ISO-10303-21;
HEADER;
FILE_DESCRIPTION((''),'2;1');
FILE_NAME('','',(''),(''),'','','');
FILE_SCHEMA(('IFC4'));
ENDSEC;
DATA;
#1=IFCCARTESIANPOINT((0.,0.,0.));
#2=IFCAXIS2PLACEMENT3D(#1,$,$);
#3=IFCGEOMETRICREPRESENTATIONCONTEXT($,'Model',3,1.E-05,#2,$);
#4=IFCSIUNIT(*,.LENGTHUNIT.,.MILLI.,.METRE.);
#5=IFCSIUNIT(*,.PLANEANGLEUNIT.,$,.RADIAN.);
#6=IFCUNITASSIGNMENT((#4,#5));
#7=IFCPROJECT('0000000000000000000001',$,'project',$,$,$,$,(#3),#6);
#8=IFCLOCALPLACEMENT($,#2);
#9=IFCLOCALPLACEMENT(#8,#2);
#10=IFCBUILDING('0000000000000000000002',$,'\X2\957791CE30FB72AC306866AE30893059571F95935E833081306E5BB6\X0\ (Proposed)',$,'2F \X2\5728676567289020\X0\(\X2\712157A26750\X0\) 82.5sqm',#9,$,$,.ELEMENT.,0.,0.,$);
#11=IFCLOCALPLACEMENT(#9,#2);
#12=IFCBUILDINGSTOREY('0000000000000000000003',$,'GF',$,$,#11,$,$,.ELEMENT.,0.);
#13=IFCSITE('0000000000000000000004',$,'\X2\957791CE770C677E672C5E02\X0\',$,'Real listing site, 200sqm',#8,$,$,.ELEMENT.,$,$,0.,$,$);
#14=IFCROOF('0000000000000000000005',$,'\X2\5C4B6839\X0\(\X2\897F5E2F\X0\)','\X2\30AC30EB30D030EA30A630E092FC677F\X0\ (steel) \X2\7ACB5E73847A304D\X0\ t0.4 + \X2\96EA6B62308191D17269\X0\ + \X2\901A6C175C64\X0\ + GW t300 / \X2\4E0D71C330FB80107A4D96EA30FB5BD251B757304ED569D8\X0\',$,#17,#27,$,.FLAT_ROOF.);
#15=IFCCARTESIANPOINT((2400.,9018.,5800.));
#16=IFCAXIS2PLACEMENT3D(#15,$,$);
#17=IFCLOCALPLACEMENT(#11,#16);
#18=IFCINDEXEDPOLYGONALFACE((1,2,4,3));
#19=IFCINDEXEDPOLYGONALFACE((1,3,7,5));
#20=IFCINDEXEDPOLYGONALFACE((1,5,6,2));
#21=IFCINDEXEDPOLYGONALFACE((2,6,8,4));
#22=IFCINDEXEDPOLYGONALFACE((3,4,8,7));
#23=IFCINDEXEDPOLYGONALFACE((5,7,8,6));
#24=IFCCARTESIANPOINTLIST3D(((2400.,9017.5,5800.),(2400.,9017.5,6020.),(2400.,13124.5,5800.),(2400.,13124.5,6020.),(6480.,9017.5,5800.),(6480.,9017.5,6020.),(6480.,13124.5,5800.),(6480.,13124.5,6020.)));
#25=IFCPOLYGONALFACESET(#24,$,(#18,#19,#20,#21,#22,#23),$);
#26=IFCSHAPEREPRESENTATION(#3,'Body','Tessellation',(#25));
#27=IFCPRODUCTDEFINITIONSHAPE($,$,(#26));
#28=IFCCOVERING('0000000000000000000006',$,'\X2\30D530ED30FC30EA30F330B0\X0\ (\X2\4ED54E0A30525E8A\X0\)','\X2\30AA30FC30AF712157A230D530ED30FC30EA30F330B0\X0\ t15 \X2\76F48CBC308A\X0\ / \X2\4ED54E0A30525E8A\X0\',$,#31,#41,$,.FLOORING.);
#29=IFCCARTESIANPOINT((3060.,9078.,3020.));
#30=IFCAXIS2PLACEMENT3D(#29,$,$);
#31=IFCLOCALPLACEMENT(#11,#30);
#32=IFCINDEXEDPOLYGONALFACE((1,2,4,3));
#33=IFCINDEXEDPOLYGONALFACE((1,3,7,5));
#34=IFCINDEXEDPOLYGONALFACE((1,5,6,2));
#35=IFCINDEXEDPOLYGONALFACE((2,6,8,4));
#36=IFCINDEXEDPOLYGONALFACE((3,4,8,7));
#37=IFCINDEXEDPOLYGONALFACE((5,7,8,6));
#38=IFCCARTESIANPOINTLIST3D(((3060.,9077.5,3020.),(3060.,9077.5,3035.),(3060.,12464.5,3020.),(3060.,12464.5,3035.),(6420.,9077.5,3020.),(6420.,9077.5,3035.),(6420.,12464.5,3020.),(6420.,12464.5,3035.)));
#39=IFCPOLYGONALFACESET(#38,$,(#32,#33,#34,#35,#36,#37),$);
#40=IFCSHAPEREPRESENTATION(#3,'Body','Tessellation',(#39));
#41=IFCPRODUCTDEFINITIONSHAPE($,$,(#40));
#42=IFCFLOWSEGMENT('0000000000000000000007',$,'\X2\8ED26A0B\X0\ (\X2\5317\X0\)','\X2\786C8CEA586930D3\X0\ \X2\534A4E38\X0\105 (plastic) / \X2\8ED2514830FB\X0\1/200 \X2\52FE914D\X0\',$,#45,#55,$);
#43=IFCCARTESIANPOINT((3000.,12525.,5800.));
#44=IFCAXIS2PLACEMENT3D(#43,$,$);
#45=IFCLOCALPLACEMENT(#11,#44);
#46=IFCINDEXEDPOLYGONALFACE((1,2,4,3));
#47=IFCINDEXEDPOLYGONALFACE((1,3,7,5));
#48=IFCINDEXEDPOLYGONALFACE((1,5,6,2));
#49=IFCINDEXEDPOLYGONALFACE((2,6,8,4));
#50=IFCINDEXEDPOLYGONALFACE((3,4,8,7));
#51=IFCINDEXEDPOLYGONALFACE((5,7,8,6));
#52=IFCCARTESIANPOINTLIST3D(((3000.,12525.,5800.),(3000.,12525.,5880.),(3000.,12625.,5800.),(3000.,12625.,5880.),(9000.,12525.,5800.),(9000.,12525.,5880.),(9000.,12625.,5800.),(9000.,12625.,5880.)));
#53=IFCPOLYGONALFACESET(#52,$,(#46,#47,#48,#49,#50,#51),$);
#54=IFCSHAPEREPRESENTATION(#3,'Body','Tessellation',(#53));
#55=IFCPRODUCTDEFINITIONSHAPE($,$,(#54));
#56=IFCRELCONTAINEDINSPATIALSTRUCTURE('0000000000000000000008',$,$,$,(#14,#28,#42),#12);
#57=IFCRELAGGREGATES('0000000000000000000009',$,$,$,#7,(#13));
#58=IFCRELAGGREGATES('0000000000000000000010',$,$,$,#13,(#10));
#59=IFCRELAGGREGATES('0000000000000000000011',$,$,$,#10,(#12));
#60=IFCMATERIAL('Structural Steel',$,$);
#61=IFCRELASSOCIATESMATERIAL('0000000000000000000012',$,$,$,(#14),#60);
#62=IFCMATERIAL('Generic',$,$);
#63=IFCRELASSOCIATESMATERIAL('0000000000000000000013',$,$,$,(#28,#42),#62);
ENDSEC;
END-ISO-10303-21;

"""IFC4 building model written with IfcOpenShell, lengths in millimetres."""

from ifc_helpers import new_model, si_unit, frame, frame_2d, origin, place, context, project, spatial, rectangle, extrude, material, element, save


model = new_model("IFC4")

# Units and contexts
model_context = context("Model", 3, precision=1e-05, world=origin())
ifc_project = project(units=[si_unit("LENGTHUNIT", "METRE", prefix="MILLI"), si_unit("PLANEANGLEUNIT", "RADIAN")], contexts=[model_context])

# Site, building, storey
site_placement = place(None, origin())
site = spatial("IfcSite", under=ifc_project, at=site_placement, Name="長野県松本市", ObjectType="Real listing site, 200sqm", CompositionType="ELEMENT", RefElevation=0.0)
building_placement = place(site_placement, origin())
building = spatial("IfcBuilding", under=site, at=building_placement, Name="長野・犬と暮らす土間広めの家 (Proposed)", ObjectType="2F 在来木造(無垢材) 82.5sqm", CompositionType="ELEMENT", ElevationOfRefHeight=0.0, ElevationOfTerrain=0.0)
storey_placement = place(building_placement, origin())
storey = spatial("IfcBuildingStorey", under=building, at=storey_placement, Name="GF", CompositionType="ELEMENT", Elevation=0.0)

# Roof
ifc_material_1 = material(Name="Structural Steel")
for number, where, name in (
    (1, (2400.0, 9018.0, 5800.0), "屋根(西帯)"),
):
    element("IfcRoof", number, at=place(storey_placement, frame(where)), inside=storey, material=ifc_material_1, Name=name, Description="ガルバリウム鋼板 (steel) 立平葺き t0.4 + 雪止め金物 + 通気層 + GW t300 / 不燃・耐積雪・寒冷地仕様", PredefinedType="FLAT_ROOF", context=model_context, shape_type="SweptSolid", body=[
        extrude(rectangle(XDim=4080.0, YDim=4107.0, at=frame_2d((2040.0, 2053.0))), frame((2400.0, 9018.0, 5800.0)), (0.0, 0.0, 1.0), 220.0),
    ])

# Covering
ifc_material_2 = material(Name="Generic")
covering_placement = place(storey_placement, frame((3060.0, 9078.0, 3020.0)))
element("IfcCovering", 2, at=covering_placement, inside=storey, material=ifc_material_2, Name="フローリング (仕上げ床)", Description="オーク無垢フローリング t15 直貼り / 仕上げ床", PredefinedType="FLOORING", context=model_context, shape_type="SweptSolid", body=[
    extrude(rectangle(XDim=3360.0, YDim=3387.0, at=frame_2d((1680.0, 1693.0))), frame((3060.0, 9078.0, 3020.0)), (0.0, 0.0, 1.0), 15.0),
])

# Flow segment
flow_segment_placement = place(storey_placement, frame((3000.0, 12525.0, 5800.0)))
element("IfcFlowSegment", 3, at=flow_segment_placement, inside=storey, material=ifc_material_2, Name="軒樋 (北)", Description="硬質塩ビ 半丸105 (plastic) / 軒先・1/200 勾配", context=model_context, shape_type="SweptSolid", body=[
    extrude(rectangle(XDim=6000.0, YDim=100.0, at=frame_2d((3000.0, 50.0))), frame((3000.0, 12525.0, 5800.0)), (0.0, 0.0, 1.0), 80.0),
])

save(model, "model.ifc")
